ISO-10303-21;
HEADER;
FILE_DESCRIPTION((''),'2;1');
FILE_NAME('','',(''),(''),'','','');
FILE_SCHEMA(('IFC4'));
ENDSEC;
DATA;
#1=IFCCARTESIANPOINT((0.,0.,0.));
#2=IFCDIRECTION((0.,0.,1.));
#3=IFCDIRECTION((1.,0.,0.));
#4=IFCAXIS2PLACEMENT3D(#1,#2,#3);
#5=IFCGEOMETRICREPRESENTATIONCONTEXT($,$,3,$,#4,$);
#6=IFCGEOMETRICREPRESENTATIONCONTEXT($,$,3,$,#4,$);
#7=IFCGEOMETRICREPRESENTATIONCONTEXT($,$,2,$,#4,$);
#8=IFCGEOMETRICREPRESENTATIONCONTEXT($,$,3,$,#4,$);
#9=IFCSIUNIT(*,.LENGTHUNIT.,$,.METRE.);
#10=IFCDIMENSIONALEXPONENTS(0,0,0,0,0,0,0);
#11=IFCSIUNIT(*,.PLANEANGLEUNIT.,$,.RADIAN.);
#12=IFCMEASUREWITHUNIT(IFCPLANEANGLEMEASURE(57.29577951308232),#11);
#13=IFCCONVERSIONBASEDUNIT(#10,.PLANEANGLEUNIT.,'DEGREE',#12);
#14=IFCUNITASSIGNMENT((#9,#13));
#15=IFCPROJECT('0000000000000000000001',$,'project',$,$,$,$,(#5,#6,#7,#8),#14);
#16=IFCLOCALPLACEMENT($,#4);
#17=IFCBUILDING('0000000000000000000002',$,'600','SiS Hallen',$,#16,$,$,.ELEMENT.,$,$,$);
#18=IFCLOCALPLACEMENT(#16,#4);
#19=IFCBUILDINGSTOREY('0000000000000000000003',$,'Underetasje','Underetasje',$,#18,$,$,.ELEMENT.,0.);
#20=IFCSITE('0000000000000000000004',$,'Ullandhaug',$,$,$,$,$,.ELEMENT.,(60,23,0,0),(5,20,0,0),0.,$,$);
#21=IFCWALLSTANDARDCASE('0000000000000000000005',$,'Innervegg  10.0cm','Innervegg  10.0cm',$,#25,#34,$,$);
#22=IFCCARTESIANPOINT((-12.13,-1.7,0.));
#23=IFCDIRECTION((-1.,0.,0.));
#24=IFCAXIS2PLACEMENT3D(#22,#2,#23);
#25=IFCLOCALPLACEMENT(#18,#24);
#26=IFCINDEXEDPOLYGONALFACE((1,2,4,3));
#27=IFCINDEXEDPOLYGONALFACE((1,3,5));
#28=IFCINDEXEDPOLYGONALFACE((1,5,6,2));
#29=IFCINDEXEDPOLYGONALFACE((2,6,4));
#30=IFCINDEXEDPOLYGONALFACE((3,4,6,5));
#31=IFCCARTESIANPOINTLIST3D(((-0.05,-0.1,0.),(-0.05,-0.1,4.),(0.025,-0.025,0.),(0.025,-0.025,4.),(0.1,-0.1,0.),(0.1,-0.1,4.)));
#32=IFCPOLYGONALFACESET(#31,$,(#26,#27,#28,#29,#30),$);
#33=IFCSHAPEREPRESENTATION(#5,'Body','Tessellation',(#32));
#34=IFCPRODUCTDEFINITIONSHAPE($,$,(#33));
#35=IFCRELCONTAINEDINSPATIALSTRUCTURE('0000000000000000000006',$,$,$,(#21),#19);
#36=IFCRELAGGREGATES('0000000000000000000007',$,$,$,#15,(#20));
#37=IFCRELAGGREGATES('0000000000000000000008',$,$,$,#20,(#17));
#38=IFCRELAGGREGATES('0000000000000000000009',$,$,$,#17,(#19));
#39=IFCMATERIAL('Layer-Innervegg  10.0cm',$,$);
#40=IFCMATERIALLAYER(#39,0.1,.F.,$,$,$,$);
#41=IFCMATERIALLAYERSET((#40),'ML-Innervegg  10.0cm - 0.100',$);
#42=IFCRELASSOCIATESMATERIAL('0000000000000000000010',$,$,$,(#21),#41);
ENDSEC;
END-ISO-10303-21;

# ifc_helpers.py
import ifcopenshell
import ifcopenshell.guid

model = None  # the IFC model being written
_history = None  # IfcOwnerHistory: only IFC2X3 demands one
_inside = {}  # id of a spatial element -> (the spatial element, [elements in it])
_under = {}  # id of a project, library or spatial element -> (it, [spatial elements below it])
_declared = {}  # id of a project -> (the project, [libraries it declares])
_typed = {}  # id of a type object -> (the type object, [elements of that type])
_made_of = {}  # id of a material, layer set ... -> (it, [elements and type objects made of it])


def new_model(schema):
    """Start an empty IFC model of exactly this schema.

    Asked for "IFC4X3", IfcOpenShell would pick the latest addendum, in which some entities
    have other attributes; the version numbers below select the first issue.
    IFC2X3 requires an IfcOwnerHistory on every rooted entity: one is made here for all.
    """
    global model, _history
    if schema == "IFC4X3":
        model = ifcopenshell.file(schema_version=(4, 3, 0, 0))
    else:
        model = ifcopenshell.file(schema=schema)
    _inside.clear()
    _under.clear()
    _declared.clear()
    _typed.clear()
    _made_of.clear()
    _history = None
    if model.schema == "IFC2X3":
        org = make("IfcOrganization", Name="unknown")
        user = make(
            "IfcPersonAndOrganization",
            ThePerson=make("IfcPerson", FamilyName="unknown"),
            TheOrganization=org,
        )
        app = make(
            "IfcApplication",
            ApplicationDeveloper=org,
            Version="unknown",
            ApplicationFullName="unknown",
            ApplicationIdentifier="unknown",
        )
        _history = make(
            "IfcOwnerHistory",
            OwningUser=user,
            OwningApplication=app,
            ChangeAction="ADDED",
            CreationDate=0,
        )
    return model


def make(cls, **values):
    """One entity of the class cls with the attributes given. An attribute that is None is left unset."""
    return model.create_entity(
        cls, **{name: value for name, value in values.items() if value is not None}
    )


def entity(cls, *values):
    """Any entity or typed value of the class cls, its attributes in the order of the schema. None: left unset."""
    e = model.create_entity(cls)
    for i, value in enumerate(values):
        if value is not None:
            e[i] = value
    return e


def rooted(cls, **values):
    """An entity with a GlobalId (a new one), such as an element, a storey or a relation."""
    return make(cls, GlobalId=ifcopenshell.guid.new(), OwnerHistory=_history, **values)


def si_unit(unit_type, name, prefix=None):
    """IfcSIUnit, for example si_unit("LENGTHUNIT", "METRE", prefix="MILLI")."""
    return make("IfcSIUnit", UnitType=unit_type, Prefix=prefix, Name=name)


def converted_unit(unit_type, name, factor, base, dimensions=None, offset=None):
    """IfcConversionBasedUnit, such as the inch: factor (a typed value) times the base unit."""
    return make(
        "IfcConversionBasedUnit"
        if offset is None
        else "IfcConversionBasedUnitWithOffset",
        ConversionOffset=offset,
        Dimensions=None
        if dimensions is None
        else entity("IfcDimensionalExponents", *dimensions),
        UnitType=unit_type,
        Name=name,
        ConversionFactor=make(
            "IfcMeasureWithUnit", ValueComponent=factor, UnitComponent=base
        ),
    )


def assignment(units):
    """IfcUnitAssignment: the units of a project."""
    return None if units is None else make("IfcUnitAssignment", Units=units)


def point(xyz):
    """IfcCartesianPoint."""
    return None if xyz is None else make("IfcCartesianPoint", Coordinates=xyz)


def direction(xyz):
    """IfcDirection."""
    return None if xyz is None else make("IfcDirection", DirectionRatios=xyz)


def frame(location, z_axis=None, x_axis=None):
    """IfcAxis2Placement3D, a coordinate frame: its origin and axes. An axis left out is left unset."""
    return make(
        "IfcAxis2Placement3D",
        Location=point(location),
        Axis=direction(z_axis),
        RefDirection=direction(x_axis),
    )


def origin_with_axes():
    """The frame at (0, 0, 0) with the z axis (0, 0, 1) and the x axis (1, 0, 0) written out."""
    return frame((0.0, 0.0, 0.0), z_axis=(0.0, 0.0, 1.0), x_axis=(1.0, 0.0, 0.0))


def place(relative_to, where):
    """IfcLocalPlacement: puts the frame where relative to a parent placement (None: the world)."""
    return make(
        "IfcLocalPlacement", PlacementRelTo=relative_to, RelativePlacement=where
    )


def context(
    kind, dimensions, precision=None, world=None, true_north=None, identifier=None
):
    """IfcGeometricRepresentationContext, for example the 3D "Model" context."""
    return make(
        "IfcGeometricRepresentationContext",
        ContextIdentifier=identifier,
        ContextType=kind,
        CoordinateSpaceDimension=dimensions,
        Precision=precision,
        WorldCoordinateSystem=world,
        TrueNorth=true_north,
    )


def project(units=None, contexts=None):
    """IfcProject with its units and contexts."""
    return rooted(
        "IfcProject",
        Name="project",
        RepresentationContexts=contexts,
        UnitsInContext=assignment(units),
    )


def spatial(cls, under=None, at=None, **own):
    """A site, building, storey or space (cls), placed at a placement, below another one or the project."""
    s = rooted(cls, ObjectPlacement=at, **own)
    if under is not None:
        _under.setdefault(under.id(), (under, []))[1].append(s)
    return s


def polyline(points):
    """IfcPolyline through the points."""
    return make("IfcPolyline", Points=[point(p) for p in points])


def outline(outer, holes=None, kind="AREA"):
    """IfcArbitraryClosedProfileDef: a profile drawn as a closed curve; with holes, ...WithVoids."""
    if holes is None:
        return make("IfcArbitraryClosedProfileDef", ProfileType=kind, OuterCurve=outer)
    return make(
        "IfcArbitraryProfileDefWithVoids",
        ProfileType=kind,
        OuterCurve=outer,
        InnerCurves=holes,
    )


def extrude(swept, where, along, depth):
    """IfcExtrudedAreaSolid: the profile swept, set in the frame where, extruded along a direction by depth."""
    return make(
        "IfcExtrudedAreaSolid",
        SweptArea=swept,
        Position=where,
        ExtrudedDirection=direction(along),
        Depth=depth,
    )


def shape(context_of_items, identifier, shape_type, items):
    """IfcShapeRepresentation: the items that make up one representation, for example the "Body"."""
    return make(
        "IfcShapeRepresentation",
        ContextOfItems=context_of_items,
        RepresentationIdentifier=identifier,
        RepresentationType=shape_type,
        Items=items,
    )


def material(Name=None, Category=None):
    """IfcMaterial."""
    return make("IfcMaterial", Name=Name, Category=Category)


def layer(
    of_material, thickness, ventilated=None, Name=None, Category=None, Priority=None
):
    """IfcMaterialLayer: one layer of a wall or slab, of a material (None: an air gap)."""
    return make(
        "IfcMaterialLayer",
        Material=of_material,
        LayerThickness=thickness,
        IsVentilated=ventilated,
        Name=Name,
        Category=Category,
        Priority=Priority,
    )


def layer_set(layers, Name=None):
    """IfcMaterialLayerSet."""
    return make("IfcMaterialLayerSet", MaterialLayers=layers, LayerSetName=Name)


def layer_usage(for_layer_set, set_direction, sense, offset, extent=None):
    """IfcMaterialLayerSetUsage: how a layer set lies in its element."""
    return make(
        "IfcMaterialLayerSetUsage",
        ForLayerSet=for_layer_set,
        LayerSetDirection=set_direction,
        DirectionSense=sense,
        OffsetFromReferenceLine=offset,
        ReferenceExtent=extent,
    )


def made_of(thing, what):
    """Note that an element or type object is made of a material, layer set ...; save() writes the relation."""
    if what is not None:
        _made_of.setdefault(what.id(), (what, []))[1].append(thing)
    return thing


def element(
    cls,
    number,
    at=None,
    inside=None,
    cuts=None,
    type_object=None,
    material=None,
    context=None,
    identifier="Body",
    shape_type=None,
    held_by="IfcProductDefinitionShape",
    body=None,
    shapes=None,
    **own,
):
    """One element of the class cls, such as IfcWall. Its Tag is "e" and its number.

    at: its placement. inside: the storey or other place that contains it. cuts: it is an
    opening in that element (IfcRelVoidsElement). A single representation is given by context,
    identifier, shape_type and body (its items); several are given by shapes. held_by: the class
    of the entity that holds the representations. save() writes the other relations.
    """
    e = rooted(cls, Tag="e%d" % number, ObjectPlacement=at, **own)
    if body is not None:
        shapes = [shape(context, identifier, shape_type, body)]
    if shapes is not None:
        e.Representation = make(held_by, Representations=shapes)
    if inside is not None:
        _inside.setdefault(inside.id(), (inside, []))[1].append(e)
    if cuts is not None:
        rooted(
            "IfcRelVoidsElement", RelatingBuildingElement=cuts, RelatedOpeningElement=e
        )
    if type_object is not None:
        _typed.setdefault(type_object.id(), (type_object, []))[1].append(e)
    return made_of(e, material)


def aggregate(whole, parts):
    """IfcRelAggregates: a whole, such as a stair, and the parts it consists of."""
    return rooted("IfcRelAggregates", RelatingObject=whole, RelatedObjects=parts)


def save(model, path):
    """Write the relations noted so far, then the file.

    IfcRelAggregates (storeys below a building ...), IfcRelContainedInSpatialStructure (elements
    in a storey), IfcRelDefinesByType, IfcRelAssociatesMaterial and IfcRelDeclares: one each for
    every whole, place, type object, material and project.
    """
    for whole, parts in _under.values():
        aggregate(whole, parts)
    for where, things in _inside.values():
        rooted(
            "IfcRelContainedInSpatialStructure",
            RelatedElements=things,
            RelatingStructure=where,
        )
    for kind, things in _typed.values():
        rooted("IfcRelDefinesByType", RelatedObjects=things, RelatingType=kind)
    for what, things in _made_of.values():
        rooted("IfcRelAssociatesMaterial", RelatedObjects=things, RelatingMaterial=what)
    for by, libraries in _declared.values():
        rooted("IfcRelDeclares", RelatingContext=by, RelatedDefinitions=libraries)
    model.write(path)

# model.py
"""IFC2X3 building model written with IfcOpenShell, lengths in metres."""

from ifc_helpers import new_model, entity, si_unit, converted_unit, frame, origin_with_axes, place, context, project, spatial, polyline, outline, extrude, material, layer, layer_set, layer_usage, element, save


model = new_model("IFC2X3")

# Units and contexts
context_of_model_1 = context(None, 3, world=origin_with_axes())
context_of_model_2 = context(None, 3, world=origin_with_axes())
context_of_model_3 = context(None, 2, world=origin_with_axes())
context_of_model_4 = context(None, 3, world=origin_with_axes())
ifc_project = project(units=[si_unit("LENGTHUNIT", "METRE"), converted_unit("PLANEANGLEUNIT", "DEGREE", entity("IfcPlaneAngleMeasure", 57.29577951308232), si_unit("PLANEANGLEUNIT", "RADIAN"), dimensions=[0, 0, 0, 0, 0, 0, 0])], contexts=[context_of_model_1, context_of_model_2, context_of_model_3, context_of_model_4])

# Site, building, storey
site = spatial("IfcSite", under=ifc_project, Name="Ullandhaug", CompositionType="ELEMENT", RefLatitude=(60, 23, 0, 0), RefLongitude=(5, 20, 0, 0), RefElevation=0.0)
building_placement = place(None, origin_with_axes())
building = spatial("IfcBuilding", under=site, at=building_placement, Name="600", Description="SiS Hallen", CompositionType="ELEMENT")
storey_placement = place(building_placement, origin_with_axes())
storey = spatial("IfcBuildingStorey", under=building, at=storey_placement, Name="Underetasje", Description="Underetasje", CompositionType="ELEMENT", Elevation=0.0)

# Wall
ifc_material_1 = material(Name="Layer-Innervegg  10.0cm")
ifc_layer_1 = layer(ifc_material_1, 0.1, ventilated=False)
ifc_layer_set_1 = layer_set([ifc_layer_1], Name="ML-Innervegg  10.0cm - 0.100")
ifc_layer_usage_1 = layer_usage(ifc_layer_set_1, "AXIS2", "POSITIVE", 0.0)
wall_1_placement = place(storey_placement, frame((-12.13, -1.7, 0.0), z_axis=(0.0, 0.0, 1.0), x_axis=(-1.0, 0.0, 0.0)))
element("IfcWallStandardCase", 1, at=wall_1_placement, inside=storey, material=ifc_layer_usage_1, Name="Innervegg  10.0cm", Description="Innervegg  10.0cm", context=context_of_model_1, shape_type="SweptSolid", body=[
    extrude(outline(polyline([(0.0, 0.0), (0.05, 0.0), (-0.05, 0.1), (0.1, 0.1), (0.0, 0.0)])), frame((0.0, 0.0, 0.0), z_axis=(0.0, 0.0, -1.0), x_axis=(1.0, 0.0, 0.0)), (0.0, 0.0, -1.0), 4.0),
])

save(model, "model.ifc")
